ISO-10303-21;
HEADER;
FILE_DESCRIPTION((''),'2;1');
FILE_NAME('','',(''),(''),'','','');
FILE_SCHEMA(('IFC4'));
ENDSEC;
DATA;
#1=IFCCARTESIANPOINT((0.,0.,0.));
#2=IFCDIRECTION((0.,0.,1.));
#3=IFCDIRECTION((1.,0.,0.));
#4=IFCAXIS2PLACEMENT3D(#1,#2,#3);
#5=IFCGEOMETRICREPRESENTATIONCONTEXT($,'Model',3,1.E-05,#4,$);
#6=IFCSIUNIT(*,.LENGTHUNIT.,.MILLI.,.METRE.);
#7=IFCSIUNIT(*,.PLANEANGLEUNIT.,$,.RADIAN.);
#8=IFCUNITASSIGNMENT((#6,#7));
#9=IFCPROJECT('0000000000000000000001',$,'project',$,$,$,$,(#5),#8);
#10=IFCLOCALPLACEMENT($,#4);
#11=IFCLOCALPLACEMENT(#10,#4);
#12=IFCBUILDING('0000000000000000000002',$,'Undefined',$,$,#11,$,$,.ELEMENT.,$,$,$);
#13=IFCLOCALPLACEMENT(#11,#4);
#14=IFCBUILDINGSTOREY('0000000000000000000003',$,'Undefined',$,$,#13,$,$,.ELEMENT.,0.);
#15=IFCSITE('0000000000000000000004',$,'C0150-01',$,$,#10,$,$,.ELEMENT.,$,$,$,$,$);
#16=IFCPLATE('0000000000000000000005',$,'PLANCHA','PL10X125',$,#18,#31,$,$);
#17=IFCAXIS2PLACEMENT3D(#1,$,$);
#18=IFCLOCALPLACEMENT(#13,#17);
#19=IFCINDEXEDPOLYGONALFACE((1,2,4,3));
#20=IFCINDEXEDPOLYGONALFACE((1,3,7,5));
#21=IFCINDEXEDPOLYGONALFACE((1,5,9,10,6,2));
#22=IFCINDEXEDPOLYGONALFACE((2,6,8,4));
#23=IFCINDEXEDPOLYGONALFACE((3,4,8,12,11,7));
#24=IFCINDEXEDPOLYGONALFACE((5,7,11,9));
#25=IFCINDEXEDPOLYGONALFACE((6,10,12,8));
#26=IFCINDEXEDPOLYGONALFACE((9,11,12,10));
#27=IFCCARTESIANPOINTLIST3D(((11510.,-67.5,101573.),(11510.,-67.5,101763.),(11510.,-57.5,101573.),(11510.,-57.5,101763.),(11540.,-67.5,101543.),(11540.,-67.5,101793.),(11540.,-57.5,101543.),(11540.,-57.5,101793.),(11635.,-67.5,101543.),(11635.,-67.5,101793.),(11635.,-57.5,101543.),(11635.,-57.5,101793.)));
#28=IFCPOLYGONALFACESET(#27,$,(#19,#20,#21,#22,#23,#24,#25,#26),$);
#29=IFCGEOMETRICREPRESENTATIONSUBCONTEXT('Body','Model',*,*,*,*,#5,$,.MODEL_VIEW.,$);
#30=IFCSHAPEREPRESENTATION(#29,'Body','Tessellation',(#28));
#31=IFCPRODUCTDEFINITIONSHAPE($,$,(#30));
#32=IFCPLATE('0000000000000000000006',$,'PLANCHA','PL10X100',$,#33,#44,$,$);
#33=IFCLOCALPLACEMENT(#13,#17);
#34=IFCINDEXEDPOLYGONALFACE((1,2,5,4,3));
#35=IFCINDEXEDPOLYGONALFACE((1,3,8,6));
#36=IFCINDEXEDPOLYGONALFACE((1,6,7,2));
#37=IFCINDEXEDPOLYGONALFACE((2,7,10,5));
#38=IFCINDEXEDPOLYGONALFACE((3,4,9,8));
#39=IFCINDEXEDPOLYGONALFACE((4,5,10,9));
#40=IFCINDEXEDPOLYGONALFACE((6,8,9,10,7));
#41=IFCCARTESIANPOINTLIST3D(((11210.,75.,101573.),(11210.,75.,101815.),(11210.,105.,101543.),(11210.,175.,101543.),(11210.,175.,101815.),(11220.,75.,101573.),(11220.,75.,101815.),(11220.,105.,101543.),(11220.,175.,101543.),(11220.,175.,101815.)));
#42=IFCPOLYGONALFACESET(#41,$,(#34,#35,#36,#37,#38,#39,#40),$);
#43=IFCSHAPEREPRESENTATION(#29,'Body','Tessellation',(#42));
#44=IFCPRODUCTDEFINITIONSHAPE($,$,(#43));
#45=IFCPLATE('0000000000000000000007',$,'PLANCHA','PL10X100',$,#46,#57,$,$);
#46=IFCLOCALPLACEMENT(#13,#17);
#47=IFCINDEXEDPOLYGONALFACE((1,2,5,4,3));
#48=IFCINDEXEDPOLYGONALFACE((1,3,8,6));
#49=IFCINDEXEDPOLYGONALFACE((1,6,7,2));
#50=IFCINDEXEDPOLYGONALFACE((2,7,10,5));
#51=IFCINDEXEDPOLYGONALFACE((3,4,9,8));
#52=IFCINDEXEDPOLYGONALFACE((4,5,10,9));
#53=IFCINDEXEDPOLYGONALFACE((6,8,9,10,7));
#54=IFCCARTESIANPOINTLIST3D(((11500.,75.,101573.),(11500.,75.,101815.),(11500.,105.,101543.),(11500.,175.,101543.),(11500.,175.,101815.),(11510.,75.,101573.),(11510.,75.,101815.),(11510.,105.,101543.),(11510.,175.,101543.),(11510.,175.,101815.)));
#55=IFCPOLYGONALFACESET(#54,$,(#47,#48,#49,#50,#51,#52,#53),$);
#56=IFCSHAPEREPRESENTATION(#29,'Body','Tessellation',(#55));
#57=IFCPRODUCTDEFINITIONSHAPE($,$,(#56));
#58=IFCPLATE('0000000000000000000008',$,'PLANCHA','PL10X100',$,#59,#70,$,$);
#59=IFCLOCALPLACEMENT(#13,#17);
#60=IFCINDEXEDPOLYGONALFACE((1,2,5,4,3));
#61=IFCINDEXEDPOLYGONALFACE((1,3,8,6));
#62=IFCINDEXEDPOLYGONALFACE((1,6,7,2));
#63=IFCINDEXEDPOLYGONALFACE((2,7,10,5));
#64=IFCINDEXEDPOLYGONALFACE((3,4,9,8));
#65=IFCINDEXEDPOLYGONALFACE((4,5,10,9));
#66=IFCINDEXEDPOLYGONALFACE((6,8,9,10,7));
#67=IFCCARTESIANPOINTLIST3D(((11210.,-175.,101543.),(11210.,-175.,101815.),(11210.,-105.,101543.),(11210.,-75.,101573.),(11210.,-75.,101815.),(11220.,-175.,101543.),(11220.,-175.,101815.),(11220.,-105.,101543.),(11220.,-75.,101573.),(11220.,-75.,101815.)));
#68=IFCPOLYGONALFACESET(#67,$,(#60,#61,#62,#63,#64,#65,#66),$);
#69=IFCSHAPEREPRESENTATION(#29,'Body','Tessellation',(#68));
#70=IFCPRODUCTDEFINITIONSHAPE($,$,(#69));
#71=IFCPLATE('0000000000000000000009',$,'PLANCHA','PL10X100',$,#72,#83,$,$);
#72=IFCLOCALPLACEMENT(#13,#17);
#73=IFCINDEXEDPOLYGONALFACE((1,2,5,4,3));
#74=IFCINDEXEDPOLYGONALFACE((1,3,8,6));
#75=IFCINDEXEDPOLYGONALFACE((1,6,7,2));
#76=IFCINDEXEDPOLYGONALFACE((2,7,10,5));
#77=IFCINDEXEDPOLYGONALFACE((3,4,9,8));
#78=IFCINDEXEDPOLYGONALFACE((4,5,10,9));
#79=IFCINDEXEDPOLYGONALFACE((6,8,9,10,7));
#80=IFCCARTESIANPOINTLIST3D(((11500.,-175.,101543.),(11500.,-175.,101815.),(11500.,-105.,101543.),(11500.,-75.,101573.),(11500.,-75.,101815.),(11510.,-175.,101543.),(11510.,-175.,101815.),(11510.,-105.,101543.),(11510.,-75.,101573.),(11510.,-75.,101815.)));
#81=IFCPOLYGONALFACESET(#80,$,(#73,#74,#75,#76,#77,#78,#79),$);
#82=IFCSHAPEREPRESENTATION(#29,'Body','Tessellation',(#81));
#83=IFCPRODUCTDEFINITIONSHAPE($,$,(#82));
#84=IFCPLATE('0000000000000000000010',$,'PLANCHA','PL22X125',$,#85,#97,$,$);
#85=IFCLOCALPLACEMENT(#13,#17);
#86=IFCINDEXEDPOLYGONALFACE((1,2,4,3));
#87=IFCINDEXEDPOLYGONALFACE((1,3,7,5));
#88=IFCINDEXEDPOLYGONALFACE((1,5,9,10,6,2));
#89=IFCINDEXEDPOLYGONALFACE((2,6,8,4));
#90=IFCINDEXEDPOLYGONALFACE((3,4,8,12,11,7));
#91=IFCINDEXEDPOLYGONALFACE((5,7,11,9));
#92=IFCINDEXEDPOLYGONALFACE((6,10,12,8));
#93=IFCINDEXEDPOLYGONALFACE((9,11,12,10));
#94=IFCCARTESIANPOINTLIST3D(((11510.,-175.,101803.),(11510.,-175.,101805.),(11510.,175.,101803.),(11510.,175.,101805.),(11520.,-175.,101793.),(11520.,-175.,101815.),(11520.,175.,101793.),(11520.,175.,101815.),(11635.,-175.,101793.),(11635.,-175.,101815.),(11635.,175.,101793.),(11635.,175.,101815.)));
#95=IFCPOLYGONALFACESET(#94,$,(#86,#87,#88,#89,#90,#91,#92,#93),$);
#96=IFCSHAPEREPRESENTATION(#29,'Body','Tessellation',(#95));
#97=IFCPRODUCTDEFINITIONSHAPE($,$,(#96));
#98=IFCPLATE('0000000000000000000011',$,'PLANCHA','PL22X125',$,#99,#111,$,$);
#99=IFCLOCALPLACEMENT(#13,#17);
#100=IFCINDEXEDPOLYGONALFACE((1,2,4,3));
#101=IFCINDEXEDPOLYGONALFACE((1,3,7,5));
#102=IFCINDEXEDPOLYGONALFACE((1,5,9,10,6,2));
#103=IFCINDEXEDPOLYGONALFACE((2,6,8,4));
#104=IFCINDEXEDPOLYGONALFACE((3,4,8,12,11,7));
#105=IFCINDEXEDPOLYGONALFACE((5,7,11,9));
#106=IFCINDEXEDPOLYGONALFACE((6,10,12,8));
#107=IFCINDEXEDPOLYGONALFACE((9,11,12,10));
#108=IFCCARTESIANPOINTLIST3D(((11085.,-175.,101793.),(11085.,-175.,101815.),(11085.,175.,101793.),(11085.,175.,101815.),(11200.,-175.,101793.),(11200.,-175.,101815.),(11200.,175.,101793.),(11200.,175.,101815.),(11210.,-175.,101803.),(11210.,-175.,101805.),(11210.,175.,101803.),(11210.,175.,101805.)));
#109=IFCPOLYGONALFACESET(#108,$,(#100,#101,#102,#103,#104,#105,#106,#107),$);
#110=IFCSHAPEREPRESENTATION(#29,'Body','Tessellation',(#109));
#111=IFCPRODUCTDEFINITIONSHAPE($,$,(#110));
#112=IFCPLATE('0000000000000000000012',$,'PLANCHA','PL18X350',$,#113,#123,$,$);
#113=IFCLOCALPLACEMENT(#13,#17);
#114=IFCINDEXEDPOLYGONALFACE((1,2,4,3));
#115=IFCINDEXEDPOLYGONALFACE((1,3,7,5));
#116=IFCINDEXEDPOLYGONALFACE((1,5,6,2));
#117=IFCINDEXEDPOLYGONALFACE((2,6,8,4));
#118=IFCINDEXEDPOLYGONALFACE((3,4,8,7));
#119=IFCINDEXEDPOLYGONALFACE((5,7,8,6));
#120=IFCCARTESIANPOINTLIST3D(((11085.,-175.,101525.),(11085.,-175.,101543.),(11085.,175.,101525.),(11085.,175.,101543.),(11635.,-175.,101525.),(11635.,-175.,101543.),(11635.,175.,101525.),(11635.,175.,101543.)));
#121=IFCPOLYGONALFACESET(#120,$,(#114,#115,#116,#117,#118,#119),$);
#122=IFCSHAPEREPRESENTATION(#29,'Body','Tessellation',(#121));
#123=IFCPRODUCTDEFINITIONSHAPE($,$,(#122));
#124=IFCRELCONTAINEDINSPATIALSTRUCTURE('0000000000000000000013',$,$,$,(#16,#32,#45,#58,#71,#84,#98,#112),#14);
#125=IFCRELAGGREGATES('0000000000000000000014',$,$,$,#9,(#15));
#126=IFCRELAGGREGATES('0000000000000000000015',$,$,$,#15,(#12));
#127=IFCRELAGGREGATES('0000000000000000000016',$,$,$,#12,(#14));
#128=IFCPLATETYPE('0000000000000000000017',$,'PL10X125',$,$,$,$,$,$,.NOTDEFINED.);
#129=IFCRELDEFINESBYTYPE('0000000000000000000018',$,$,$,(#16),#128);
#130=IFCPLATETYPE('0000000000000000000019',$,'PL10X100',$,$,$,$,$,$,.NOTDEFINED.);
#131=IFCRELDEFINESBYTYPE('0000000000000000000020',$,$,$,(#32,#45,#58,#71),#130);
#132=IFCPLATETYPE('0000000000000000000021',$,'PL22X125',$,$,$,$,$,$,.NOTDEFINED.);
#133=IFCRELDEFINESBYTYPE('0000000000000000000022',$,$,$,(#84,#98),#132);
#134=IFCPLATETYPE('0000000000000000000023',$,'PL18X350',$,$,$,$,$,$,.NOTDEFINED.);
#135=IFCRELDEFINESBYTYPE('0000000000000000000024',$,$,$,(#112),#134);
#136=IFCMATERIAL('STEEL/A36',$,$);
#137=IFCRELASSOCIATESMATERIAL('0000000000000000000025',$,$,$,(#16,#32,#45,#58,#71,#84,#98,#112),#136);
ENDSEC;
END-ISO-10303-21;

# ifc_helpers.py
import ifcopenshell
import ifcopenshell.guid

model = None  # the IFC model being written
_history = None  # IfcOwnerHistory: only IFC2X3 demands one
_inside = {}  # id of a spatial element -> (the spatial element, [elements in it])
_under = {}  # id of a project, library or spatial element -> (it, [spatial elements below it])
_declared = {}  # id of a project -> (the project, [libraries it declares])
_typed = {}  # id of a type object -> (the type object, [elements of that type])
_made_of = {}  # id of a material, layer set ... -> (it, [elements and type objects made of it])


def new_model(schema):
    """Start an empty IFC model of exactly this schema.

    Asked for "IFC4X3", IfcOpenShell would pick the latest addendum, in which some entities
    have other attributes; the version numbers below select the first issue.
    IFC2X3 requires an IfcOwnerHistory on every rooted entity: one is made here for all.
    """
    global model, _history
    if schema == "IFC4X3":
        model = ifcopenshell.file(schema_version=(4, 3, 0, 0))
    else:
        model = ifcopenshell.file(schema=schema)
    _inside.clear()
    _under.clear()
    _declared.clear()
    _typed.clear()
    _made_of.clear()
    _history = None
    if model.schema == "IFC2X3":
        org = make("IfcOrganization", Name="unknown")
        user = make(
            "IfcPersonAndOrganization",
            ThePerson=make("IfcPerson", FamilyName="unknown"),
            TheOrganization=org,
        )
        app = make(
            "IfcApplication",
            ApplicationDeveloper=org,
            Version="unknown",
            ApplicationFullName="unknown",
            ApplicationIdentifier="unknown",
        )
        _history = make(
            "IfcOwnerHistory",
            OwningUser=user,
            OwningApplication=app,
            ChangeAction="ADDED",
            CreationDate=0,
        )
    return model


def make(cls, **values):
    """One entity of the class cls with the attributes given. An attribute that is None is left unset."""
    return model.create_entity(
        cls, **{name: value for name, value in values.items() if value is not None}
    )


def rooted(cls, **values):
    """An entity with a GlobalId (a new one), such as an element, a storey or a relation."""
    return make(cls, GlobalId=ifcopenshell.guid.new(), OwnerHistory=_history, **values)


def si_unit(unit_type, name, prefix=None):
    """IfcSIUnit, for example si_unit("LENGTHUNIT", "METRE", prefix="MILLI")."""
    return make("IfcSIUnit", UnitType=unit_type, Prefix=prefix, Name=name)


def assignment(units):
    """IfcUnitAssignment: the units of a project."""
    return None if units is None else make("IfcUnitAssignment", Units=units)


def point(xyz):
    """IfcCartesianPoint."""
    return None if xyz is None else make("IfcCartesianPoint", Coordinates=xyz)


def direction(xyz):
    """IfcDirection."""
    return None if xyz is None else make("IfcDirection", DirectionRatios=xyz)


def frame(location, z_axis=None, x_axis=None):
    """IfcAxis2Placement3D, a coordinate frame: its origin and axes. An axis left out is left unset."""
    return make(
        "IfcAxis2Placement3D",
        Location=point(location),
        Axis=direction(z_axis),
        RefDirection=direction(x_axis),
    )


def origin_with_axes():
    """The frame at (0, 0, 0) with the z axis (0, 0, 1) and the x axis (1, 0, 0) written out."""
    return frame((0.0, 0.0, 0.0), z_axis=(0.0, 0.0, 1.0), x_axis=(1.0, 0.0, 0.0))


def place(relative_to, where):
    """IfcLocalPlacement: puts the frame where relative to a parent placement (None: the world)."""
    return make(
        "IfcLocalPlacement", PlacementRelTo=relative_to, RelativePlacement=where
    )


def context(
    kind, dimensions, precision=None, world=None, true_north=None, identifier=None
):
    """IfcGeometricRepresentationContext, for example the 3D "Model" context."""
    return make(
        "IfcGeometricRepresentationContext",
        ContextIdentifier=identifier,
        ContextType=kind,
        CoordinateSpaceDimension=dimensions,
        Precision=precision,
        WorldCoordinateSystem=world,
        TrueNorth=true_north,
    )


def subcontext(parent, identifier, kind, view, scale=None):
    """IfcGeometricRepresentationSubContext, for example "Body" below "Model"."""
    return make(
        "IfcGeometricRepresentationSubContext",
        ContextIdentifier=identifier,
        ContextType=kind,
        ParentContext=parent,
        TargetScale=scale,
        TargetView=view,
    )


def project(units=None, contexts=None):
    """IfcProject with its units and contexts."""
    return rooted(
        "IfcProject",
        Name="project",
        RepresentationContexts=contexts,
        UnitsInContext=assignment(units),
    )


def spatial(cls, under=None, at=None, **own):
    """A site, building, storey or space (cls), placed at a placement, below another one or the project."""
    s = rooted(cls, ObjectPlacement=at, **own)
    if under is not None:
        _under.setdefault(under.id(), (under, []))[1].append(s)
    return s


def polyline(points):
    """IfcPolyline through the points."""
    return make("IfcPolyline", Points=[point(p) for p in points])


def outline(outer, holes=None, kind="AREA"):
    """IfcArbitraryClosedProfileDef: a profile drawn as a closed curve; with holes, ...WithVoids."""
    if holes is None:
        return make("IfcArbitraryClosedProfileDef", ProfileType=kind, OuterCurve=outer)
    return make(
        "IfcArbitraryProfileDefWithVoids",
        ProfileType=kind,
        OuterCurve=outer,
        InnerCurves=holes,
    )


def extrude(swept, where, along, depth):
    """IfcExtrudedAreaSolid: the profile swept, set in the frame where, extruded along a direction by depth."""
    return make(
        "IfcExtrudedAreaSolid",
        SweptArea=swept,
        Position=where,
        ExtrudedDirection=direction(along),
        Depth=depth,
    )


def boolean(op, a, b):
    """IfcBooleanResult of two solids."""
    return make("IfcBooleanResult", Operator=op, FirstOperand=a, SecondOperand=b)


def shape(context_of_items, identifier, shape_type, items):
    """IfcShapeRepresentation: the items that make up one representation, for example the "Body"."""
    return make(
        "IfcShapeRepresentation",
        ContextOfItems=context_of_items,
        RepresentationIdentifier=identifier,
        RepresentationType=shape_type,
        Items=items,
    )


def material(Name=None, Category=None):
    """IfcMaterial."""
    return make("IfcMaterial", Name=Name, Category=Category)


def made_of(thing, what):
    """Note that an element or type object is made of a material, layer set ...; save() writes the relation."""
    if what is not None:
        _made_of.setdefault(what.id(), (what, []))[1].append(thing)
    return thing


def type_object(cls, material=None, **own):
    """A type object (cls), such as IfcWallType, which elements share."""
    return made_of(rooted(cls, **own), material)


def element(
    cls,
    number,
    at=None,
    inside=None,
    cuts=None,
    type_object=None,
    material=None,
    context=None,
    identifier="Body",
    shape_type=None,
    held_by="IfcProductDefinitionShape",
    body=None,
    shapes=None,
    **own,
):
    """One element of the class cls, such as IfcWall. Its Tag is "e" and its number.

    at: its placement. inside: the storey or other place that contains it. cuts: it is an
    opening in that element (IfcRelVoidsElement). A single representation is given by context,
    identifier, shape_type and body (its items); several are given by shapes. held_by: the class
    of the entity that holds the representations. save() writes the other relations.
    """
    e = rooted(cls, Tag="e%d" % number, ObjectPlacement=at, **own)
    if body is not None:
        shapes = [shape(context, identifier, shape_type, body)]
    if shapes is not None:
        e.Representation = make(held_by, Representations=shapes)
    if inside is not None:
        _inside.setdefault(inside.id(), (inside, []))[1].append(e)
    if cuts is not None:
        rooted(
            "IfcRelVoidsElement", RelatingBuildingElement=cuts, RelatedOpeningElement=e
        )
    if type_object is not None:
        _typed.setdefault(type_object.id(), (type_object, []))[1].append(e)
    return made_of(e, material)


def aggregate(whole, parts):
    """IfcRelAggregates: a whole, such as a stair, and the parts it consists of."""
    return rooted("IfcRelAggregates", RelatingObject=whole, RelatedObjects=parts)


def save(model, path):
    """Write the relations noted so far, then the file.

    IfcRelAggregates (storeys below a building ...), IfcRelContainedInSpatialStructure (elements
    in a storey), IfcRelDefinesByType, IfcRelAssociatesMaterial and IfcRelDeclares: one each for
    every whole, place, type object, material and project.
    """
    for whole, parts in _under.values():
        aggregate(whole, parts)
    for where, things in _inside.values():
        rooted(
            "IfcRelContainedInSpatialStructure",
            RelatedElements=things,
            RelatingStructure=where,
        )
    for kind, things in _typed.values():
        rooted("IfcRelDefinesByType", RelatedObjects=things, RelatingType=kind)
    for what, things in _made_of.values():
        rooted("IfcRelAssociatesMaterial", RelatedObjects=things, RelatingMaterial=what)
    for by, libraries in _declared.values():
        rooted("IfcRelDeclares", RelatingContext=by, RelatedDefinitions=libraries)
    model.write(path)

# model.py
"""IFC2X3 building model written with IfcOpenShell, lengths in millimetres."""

from ifc_helpers import new_model, si_unit, frame, origin_with_axes, place, context, subcontext, project, spatial, polyline, outline, extrude, boolean, material, type_object, element, save


model = new_model("IFC2X3")

# Units and contexts
model_context = context("Model", 3, precision=1e-05, world=origin_with_axes())
body_context = subcontext(model_context, "Body", "Model", "MODEL_VIEW")
ifc_project = project(units=[si_unit("LENGTHUNIT", "METRE", prefix="MILLI"), si_unit("PLANEANGLEUNIT", "RADIAN")], contexts=[model_context])

# Site, building, storey
site_placement = place(None, origin_with_axes())
site = spatial("IfcSite", under=ifc_project, at=site_placement, Name="C0150-01", CompositionType="ELEMENT")
building_placement = place(site_placement, origin_with_axes())
building = spatial("IfcBuilding", under=site, at=building_placement, Name="Undefined", CompositionType="ELEMENT")
storey_placement = place(building_placement, origin_with_axes())
storey = spatial("IfcBuildingStorey", under=building, at=storey_placement, Name="Undefined", CompositionType="ELEMENT", Elevation=0.0)

# Shared definitions
ifc_material_1 = material(Name="STEEL/A36")

# Plates
plate_type_1 = type_object("IfcPlateType", Name="PL10X125", PredefinedType="NOTDEFINED")
for number, where, z_axis, x_axis, name in (
    (1, (11635.0, -62.5, 101793.0), (0.0, 1.0, 0.0), (0.0, 0.0, -1.0), "PLANCHA"),
):
    element("IfcPlate", number, at=place(storey_placement, frame(where, z_axis=z_axis, x_axis=x_axis)), inside=storey, type_object=plate_type_1, material=ifc_material_1, Name=name, Description="PL10X125", context=body_context, shape_type="SweptSolid", body=[
        extrude(outline(polyline([(0.0, 0.0), (250.0, 0.0), (250.0, 95.0), (220.0, 125.0), (30.0, 125.0), (0.0, 95.0), (0.0, 0.0)])), frame((0.0, 0.0, -5.0), z_axis=(0.0, 0.0, 1.0), x_axis=(1.0, 0.0, 0.0)), (0.0, 0.0, 1.0), 10.0),
    ])
plate_type_2 = type_object("IfcPlateType", Name="PL10X100", PredefinedType="NOTDEFINED")
for number, where, z_axis, x_axis, name in (
    (2, (11215.0, 175.0, 101815.0), (-1.0, 0.0, 0.0), (0.0, 0.0, -1.0), "PLANCHA"),
    (3, (11505.0, 175.0, 101815.0), (-1.0, 0.0, 0.0), (0.0, 0.0, -1.0), "PLANCHA"),
    (4, (11215.0, -175.0, 101815.0), (1.0, 0.0, 0.0), (0.0, 0.0, -1.0), "PLANCHA"),
    (5, (11505.0, -175.0, 101815.0), (1.0, 0.0, 0.0), (0.0, 0.0, -1.0), "PLANCHA"),
):
    element("IfcPlate", number, at=place(storey_placement, frame(where, z_axis=z_axis, x_axis=x_axis)), inside=storey, type_object=plate_type_2, material=ifc_material_1, Name=name, Description="PL10X100", context=body_context, shape_type="SweptSolid", body=[
        extrude(outline(polyline([(0.0, 0.0), (272.0, 0.0), (272.0, 70.0), (242.0, 100.0), (0.0, 100.0), (0.0, 0.0)])), frame((0.0, 0.0, -5.0), z_axis=(0.0, 0.0, 1.0), x_axis=(1.0, 0.0, 0.0)), (0.0, 0.0, 1.0), 10.0),
    ])
plate_type_3 = type_object("IfcPlateType", Name="PL22X125", PredefinedType="NOTDEFINED")
plate_1_placement = place(storey_placement, frame((11510.0, 175.0, 101804.0), z_axis=(0.0, 0.0, 1.0), x_axis=(0.0, -1.0, 0.0)))
element("IfcPlate", 6, at=plate_1_placement, inside=storey, type_object=plate_type_3, material=ifc_material_1, Name="PLANCHA", Description="PL22X125", context=body_context, shape_type="CSG", body=[
    boolean("DIFFERENCE", boolean("DIFFERENCE", extrude(outline(polyline([(0.0, 0.0), (350.0, 0.0), (350.0, 125.0), (0.0, 125.0), (0.0, 0.0)])), frame((0.0, 0.0, -11.0), z_axis=(0.0, 0.0, 1.0), x_axis=(1.0, 0.0, 0.0)), (0.0, 0.0, 1.0), 22.0), extrude(outline(polyline([(0.0, 0.0), (10.0, 0.0), (10.0, 10.0), (0.0, 0.0)])), frame((352.5, 0.0, 1.0), z_axis=(-1.0, 0.0, 0.0), x_axis=(0.0, 0.0, 1.0)), (0.0, 0.0, 1.0), 355.0)), extrude(outline(polyline([(0.0, 0.0), (10.0, 0.0), (10.0, 10.0), (0.0, 0.0)])), frame((-2.5, 0.0, -1.0), z_axis=(1.0, 0.0, 0.0), x_axis=(0.0, 0.0, -1.0)), (0.0, 0.0, 1.0), 355.0)),
])
plate_2_placement = place(storey_placement, frame((11210.0, 175.0, 101804.0), z_axis=(0.0, 0.0, -1.0), x_axis=(0.0, -1.0, 0.0)))
element("IfcPlate", 7, at=plate_2_placement, inside=storey, type_object=plate_type_3, material=ifc_material_1, Name="PLANCHA", Description="PL22X125", context=body_context, shape_type="CSG", body=[
    boolean("DIFFERENCE", boolean("DIFFERENCE", extrude(outline(polyline([(0.0, 0.0), (350.0, 0.0), (350.0, 125.0), (0.0, 125.0), (0.0, 0.0)])), frame((0.0, 0.0, -11.0), z_axis=(0.0, 0.0, 1.0), x_axis=(1.0, 0.0, 0.0)), (0.0, 0.0, 1.0), 22.0), extrude(outline(polyline([(0.0, 0.0), (10.0, 0.0), (10.0, 10.0), (0.0, 0.0)])), frame((-2.5, 0.0, -1.0), z_axis=(1.0, 0.0, 0.0), x_axis=(0.0, 0.0, -1.0)), (0.0, 0.0, 1.0), 355.0)), extrude(outline(polyline([(0.0, 0.0), (10.0, 0.0), (10.0, 10.0), (0.0, 0.0)])), frame((352.5, 0.0, 1.0), z_axis=(-1.0, 0.0, 0.0), x_axis=(0.0, 0.0, 1.0)), (0.0, 0.0, 1.0), 355.0)),
])
plate_type_4 = type_object("IfcPlateType", Name="PL18X350", PredefinedType="NOTDEFINED")
plate_3_placement = place(storey_placement, frame((11635.0, 175.0, 101534.0), z_axis=(0.0, 0.0, -1.0), x_axis=(0.0, -1.0, 0.0)))
element("IfcPlate", 8, at=plate_3_placement, inside=storey, type_object=plate_type_4, material=ifc_material_1, Name="PLANCHA", Description="PL18X350", context=body_context, shape_type="SweptSolid", body=[
    extrude(outline(polyline([(0.0, 0.0), (350.0, 0.0), (350.0, 550.0), (0.0, 550.0), (0.0, 0.0)])), frame((0.0, 0.0, -9.0), z_axis=(0.0, 0.0, 1.0), x_axis=(1.0, 0.0, 0.0)), (0.0, 0.0, 1.0), 18.0),
])

save(model, "model.ifc")
